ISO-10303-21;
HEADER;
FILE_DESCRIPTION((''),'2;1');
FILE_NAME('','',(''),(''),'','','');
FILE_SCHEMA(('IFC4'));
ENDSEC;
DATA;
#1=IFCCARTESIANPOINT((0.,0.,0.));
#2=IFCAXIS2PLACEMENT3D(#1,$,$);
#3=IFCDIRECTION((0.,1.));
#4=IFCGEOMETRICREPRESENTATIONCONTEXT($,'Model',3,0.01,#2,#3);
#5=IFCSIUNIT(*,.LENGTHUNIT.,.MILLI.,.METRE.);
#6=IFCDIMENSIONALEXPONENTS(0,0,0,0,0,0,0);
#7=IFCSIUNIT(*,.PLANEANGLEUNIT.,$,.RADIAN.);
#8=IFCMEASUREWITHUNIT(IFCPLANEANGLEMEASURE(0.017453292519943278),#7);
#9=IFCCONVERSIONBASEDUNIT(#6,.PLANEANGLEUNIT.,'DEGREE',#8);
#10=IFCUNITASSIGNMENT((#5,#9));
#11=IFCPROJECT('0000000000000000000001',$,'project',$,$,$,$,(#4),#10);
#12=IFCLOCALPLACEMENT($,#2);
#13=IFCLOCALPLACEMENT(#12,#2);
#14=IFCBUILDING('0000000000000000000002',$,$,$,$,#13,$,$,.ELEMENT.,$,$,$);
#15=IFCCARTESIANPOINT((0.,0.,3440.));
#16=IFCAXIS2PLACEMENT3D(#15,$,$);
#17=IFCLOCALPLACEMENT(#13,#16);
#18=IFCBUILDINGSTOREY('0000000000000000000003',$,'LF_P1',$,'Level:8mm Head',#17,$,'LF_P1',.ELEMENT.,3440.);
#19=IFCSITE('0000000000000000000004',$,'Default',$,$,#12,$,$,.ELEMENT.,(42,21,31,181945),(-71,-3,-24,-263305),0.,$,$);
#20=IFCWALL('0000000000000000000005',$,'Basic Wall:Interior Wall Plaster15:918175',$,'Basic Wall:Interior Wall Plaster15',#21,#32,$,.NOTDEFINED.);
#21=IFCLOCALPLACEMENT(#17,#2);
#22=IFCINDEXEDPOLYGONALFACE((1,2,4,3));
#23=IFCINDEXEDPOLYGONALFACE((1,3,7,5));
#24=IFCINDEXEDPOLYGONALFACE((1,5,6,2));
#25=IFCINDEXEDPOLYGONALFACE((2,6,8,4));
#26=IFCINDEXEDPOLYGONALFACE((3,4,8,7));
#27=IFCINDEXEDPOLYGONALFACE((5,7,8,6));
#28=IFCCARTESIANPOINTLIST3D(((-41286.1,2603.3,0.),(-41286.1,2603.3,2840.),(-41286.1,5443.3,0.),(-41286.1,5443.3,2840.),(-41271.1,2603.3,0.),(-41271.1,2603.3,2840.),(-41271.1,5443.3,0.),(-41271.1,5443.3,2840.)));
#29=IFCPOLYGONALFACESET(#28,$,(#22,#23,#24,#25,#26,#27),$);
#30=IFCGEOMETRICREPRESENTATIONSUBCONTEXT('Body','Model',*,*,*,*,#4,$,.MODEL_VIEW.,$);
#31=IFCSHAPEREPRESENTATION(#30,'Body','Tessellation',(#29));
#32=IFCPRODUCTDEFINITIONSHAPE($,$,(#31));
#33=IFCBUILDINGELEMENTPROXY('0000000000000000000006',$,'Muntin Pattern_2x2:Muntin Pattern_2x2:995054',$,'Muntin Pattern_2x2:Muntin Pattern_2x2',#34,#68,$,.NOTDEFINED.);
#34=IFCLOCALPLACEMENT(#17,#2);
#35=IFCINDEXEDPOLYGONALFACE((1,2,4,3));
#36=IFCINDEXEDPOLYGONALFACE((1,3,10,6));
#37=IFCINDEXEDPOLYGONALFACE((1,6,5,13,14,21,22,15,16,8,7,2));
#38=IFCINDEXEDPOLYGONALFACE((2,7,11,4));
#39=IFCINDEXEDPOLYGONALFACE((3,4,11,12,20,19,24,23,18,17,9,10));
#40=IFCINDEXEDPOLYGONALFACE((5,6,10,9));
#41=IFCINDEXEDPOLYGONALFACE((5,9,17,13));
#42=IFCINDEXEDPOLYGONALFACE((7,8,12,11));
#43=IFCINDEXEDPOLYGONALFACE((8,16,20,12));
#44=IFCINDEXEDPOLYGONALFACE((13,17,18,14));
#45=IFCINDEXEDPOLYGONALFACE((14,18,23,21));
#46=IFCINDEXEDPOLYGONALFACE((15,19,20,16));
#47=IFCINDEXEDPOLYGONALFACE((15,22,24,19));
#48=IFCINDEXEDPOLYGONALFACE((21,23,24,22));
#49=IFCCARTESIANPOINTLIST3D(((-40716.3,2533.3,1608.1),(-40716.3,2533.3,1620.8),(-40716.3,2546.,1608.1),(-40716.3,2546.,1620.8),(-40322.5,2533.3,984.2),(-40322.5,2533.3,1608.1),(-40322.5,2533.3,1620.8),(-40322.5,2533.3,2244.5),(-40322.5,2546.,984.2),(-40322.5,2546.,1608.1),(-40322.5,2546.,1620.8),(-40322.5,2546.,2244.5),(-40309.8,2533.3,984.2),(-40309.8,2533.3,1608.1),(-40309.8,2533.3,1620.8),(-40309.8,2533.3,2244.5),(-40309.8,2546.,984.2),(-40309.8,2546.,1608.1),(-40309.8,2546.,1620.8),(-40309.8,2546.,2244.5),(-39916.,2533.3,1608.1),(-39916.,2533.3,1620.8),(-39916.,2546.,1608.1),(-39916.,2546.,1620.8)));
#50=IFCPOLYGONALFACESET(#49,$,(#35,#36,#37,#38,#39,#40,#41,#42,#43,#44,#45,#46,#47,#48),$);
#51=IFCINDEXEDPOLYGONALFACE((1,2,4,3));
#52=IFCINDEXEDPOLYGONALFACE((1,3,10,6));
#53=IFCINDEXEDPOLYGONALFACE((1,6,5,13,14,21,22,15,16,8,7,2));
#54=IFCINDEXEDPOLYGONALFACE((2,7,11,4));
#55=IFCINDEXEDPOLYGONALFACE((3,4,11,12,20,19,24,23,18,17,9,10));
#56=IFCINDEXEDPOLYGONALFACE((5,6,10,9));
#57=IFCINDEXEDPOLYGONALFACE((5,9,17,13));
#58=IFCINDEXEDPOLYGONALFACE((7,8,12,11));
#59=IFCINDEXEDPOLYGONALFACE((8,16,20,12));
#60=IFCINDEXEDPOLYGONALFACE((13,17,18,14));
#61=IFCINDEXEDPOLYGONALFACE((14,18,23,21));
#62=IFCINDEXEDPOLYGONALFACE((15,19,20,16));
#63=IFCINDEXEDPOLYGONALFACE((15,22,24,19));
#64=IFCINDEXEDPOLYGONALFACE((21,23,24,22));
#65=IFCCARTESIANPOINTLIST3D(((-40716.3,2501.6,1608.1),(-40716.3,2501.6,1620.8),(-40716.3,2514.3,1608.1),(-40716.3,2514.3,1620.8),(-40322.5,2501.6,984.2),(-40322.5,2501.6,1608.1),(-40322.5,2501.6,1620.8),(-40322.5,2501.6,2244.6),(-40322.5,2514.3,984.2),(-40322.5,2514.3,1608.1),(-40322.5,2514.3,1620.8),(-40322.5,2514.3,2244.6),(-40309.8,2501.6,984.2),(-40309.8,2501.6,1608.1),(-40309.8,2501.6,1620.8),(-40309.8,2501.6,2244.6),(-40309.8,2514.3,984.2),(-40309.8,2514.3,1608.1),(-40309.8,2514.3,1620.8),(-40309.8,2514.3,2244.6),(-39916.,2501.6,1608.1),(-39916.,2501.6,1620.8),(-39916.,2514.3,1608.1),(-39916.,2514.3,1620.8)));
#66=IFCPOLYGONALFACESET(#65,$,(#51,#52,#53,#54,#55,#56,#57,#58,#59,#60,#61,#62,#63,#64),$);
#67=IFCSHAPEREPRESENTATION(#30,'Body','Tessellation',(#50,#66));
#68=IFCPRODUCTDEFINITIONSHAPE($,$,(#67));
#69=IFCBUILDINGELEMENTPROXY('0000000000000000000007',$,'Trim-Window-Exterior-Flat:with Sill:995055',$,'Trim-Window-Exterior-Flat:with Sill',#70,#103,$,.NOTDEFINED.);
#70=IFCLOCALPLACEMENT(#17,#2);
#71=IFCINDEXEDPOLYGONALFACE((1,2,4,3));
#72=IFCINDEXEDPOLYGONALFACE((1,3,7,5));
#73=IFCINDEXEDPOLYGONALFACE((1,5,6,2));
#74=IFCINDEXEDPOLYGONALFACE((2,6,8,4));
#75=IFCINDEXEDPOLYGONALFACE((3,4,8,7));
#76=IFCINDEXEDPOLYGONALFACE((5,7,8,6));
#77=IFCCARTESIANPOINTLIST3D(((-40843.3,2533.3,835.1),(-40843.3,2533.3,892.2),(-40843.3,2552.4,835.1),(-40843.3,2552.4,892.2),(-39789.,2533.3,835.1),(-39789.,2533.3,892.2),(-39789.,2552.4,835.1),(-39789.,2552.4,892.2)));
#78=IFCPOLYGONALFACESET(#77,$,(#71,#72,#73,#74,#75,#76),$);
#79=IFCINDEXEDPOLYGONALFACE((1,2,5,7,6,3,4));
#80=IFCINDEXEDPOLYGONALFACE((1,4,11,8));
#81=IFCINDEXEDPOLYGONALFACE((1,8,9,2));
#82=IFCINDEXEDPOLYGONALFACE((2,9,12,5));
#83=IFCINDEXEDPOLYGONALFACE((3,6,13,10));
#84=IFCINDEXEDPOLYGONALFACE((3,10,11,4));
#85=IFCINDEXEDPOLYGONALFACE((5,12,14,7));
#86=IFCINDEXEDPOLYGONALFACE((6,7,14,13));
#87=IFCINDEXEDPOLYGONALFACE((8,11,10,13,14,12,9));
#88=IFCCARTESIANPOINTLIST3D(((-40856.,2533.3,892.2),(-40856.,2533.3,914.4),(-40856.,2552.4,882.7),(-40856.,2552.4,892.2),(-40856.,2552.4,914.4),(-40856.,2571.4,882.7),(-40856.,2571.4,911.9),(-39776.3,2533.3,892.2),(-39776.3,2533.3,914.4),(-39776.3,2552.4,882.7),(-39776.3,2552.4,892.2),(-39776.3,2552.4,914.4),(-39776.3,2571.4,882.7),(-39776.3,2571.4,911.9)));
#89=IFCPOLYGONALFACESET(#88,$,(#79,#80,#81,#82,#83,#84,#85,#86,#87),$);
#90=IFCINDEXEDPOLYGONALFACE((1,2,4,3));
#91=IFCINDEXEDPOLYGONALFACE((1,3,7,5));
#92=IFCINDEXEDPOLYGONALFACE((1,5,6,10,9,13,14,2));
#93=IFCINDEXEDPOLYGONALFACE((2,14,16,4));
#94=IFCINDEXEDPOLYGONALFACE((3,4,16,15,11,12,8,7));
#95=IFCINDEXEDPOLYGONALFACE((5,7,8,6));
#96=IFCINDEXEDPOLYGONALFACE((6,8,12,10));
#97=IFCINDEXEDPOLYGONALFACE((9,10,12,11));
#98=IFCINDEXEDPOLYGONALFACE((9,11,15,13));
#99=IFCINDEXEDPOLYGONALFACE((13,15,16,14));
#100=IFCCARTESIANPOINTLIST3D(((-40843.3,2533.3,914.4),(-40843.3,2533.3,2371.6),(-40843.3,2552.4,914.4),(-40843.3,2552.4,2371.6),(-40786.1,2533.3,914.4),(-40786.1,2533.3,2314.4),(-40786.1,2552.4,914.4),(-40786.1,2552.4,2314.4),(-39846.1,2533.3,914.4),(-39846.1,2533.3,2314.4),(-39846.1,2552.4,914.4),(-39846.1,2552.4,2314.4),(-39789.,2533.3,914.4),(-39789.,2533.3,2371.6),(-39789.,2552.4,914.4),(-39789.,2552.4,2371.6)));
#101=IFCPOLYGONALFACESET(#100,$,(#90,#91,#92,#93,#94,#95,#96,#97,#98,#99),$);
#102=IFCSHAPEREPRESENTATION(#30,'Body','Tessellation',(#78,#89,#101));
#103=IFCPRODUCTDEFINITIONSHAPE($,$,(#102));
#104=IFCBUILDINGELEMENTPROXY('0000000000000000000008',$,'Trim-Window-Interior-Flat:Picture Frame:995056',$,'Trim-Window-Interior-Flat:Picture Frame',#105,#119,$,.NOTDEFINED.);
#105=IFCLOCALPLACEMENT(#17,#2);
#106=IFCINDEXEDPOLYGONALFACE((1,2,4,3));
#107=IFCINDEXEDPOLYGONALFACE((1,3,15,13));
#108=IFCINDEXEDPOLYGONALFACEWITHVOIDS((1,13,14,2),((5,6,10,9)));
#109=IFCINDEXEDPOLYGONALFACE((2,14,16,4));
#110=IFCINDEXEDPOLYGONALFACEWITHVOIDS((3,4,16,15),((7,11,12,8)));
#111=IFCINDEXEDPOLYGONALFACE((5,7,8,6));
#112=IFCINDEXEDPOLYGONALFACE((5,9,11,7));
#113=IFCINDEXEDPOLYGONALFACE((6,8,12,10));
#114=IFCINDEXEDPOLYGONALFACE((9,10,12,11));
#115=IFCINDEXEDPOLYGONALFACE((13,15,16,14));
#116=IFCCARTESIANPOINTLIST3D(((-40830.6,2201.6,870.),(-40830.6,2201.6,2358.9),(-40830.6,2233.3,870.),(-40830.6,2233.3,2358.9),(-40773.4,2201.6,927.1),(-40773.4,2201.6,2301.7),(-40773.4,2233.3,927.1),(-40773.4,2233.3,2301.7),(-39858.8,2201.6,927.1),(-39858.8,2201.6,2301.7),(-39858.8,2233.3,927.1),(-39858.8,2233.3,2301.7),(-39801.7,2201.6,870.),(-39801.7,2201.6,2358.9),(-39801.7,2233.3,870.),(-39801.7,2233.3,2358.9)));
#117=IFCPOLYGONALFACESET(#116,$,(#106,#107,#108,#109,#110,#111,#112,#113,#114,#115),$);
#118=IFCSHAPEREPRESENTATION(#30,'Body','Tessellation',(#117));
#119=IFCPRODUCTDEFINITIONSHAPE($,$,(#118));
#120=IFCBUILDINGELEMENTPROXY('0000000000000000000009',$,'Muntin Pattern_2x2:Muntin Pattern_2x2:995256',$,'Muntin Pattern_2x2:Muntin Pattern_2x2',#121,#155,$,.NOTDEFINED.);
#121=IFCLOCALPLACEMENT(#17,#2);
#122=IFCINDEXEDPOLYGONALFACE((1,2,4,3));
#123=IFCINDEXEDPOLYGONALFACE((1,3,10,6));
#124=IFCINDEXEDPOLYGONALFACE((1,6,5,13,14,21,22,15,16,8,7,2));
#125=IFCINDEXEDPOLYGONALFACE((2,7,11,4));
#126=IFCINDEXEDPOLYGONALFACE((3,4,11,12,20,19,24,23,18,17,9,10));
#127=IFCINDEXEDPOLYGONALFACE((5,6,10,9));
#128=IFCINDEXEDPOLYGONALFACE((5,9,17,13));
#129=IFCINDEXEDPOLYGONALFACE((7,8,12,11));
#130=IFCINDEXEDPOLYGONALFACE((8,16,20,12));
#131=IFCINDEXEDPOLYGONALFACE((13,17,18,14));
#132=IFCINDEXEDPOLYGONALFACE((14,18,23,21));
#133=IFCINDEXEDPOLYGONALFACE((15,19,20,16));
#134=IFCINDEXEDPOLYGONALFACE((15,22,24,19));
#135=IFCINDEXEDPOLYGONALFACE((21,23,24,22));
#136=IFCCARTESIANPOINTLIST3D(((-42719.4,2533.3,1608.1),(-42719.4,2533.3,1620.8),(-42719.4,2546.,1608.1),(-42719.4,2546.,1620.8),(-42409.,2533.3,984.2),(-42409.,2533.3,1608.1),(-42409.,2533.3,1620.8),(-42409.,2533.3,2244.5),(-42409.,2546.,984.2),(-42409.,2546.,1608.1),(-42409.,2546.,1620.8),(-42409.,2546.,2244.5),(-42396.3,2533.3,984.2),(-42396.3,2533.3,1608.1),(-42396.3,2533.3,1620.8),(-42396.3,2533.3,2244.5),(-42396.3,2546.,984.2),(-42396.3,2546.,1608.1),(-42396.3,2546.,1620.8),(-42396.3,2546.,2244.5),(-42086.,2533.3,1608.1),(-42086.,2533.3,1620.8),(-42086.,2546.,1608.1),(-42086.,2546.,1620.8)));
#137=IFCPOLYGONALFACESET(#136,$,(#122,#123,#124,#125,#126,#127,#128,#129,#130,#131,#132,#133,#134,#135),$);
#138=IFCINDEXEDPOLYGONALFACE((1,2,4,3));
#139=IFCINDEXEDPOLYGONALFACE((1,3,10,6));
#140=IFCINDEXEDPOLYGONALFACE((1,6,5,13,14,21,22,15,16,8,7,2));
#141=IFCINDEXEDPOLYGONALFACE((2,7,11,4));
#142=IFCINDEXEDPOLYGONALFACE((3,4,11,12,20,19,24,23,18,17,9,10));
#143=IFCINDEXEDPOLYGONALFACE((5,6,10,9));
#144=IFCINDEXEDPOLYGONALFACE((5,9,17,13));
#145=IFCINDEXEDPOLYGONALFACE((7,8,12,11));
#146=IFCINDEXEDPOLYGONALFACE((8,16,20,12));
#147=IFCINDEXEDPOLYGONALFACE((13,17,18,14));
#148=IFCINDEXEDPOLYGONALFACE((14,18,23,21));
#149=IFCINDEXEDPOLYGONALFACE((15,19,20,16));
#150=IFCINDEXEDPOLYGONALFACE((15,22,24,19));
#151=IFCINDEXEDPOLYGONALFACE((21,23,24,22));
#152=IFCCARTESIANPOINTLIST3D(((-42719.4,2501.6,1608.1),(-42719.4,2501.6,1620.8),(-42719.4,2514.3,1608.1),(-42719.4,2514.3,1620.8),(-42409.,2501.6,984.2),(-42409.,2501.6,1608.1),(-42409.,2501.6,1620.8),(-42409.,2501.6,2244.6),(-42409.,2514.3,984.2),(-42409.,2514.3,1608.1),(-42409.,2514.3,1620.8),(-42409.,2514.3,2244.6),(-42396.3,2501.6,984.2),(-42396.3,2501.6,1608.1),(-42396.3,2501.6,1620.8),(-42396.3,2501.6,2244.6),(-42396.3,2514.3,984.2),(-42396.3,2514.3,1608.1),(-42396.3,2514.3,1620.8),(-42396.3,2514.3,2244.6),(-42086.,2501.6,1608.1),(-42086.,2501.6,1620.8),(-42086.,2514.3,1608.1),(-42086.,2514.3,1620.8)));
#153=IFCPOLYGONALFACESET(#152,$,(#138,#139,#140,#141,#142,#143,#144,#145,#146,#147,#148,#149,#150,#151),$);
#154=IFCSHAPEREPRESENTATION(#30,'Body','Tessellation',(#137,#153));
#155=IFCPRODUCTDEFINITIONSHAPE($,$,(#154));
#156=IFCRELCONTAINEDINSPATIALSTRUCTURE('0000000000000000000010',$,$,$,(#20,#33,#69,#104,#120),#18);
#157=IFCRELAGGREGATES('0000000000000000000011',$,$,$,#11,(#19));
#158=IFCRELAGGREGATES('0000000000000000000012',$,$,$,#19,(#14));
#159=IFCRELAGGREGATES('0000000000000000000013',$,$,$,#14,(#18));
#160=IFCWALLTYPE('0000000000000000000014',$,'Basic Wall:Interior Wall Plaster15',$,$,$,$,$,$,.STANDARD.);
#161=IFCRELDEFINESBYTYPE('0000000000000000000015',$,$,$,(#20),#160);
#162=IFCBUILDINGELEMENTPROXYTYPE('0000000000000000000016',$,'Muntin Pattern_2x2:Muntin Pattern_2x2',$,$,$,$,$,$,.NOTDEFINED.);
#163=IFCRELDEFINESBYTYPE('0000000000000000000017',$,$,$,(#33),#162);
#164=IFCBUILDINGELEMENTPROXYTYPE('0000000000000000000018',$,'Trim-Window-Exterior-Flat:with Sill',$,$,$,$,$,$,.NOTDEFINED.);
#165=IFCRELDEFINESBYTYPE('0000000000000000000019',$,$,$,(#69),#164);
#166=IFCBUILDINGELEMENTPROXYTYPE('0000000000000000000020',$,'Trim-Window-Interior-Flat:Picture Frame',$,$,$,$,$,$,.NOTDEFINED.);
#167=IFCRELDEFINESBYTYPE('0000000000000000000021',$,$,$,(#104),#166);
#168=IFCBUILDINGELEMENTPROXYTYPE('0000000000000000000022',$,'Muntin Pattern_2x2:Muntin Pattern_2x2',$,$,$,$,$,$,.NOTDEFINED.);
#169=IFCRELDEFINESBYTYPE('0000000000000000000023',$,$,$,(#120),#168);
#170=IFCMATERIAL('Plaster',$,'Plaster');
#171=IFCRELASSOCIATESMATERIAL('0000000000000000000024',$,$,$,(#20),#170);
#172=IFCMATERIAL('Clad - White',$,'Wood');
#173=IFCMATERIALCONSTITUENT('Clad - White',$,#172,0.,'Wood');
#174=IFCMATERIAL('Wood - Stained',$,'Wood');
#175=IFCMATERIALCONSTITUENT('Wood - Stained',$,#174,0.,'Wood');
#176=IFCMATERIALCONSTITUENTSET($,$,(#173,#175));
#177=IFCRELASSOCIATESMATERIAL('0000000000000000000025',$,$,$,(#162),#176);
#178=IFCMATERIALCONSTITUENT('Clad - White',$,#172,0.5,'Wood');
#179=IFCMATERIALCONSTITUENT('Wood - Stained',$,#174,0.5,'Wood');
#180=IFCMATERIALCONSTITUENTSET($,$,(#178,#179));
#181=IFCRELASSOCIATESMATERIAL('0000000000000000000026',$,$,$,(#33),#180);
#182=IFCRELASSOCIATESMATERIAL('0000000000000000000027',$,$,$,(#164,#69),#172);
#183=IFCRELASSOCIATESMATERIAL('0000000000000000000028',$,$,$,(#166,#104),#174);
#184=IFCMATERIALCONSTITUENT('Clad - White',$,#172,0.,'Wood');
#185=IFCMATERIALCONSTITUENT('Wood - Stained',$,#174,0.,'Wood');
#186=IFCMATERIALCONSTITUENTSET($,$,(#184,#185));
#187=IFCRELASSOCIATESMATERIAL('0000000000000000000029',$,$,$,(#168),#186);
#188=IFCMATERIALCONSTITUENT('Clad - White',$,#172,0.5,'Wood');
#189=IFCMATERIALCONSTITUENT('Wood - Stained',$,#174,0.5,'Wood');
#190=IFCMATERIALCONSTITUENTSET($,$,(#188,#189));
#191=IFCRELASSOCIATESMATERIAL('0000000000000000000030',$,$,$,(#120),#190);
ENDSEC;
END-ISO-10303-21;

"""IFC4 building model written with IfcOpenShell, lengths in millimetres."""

from ifc_helpers import new_model, entity, si_unit, converted_unit, direction, frame, origin, place, context, subcontext, project, spatial, indexed_curve, outline, extrude, source, transform, mapped, material, constituent, constituent_set, type_object, type_shapes, element, save


model = new_model("IFC4")

# Units and contexts
model_context = context("Model", 3, precision=0.01, world=origin(), true_north=direction((0.0, 1.0)))
body_context = subcontext(model_context, "Body", "Model", "MODEL_VIEW")
ifc_project = project(units=[si_unit("LENGTHUNIT", "METRE", prefix="MILLI"), converted_unit("PLANEANGLEUNIT", "DEGREE", entity("IfcPlaneAngleMeasure", 0.017453292519943278), si_unit("PLANEANGLEUNIT", "RADIAN"), dimensions=[0, 0, 0, 0, 0, 0, 0])], contexts=[model_context])

# Site, building, storey
site_placement = place(None, origin())
site = spatial("IfcSite", under=ifc_project, at=site_placement, Name="Default", CompositionType="ELEMENT", RefLatitude=(42, 21, 31, 181945), RefLongitude=(-71, -3, -24, -263305), RefElevation=0.0)
building_placement = place(site_placement, origin())
building = spatial("IfcBuilding", under=site, at=building_placement, CompositionType="ELEMENT")
storey_placement = place(building_placement, frame((0.0, 0.0, 3440.0)))
storey = spatial("IfcBuildingStorey", under=building, at=storey_placement, Name="LF_P1", ObjectType="Level:8mm Head", LongName="LF_P1", CompositionType="ELEMENT", Elevation=3440.0)

# Wall
ifc_material_1 = material(Name="Plaster", Category="Plaster")
wall_type_1 = type_object("IfcWallType", Name="Basic Wall:Interior Wall Plaster15", PredefinedType="STANDARD")
wall_1_placement = place(storey_placement, frame((-41278.6, 5443.3, 0.0), z_axis=(0.0, 0.0, 1.0), x_axis=(0.0, -1.0, 0.0)))
element("IfcWall", 1, at=wall_1_placement, inside=storey, type_object=wall_type_1, material=ifc_material_1, Name="Basic Wall:Interior Wall Plaster15:918175", ObjectType="Basic Wall:Interior Wall Plaster15", PredefinedType="NOTDEFINED", context=body_context, shape_type="SweptSolid", body=[
    extrude(outline(indexed_curve([(2840.0, 7.5), (0.0, 7.5), (0.0, -7.5), (2840.0, -7.5), (2840.0, 7.5)], self_intersect=False)), origin(), (0.0, 0.0, 1.0), 2840.0),
])

# Building element proxies
ifc_material_2 = material(Name="Clad - White", Category="Wood")
ifc_constituent_1 = constituent(ifc_material_2, Name="Clad - White", Category="Wood", fraction=0.5)
ifc_material_3 = material(Name="Wood - Stained", Category="Wood")
ifc_constituent_2 = constituent(ifc_material_3, Name="Wood - Stained", Category="Wood", fraction=0.5)
ifc_constituent_set_1 = constituent_set(constituents=[ifc_constituent_1, ifc_constituent_2])
ifc_constituent_3 = constituent(ifc_material_2, Name="Clad - White", Category="Wood", fraction=0.0)
ifc_constituent_4 = constituent(ifc_material_3, Name="Wood - Stained", Category="Wood", fraction=0.0)
ifc_constituent_set_2 = constituent_set(constituents=[ifc_constituent_3, ifc_constituent_4])
building_element_proxy_type_1 = type_object("IfcBuildingElementProxyType", Name="Muntin Pattern_2x2:Muntin Pattern_2x2", PredefinedType="NOTDEFINED", material=ifc_constituent_set_2)
shared_shape_1 = source(origin(), body_context, "Body", "SweptSolid", [
    extrude(outline(indexed_curve([(6.4, -6.4), (630.1, -6.4), (630.1, 6.3), (6.4, 6.3), (6.4, 400.2), (-6.3, 400.2), (-6.3, 6.3), (-630.2, 6.3), (-630.2, -6.4), (-6.3, -6.4), (-6.3, -400.1), (6.4, -400.1), (6.4, -6.4)], self_intersect=False)), frame((0.0, -22.2, 630.1), z_axis=(0.0, 1.0, 0.0), x_axis=(0.0, 0.0, 1.0)), (0.0, 0.0, 1.0), 12.7),
    extrude(outline(indexed_curve([(6.4, -6.4), (630.2, -6.4), (630.2, 6.3), (6.4, 6.3), (6.4, 400.2), (-6.3, 400.2), (-6.3, 6.3), (-630.2, 6.3), (-630.2, -6.4), (-6.3, -6.4), (-6.3, -400.1), (6.4, -400.1), (6.4, -6.4)], self_intersect=False)), frame((0.0, 9.5, 630.2), z_axis=(0.0, 1.0, 0.0), x_axis=(0.0, 0.0, 1.0)), (0.0, 0.0, 1.0), 12.7),
])
type_shapes(building_element_proxy_type_1, [shared_shape_1])
proxy_1_placement = place(storey_placement, frame((-40316.1, 2523.8, 984.2), z_axis=(0.0, 0.0, 1.0), x_axis=(-1.0, 0.0, 0.0)))
element("IfcBuildingElementProxy", 2, at=proxy_1_placement, inside=storey, type_object=building_element_proxy_type_1, material=ifc_constituent_set_1, Name="Muntin Pattern_2x2:Muntin Pattern_2x2:995054", ObjectType="Muntin Pattern_2x2:Muntin Pattern_2x2", PredefinedType="NOTDEFINED", context=body_context, shape_type="MappedRepresentation", body=[
    mapped(shared_shape_1, transform((0.0, 0.0, 0.0), scale=1.0)),
])
building_element_proxy_type_2 = type_object("IfcBuildingElementProxyType", Name="Trim-Window-Exterior-Flat:with Sill", PredefinedType="NOTDEFINED", material=ifc_material_2)
shared_shape_2 = source(origin(), body_context, "Body", "SweptSolid", [
    extrude(outline(indexed_curve([(-28.6, -527.1), (28.6, -527.1), (28.6, 527.1), (-28.6, 527.1), (-28.6, -527.1)], self_intersect=False)), frame((0.0, 1450.8, 0.0), z_axis=(0.0, 0.0, 1.0), x_axis=(0.0, 1.0, 0.0)), (0.0, 0.0, 1.0), 19.0),
    extrude(outline(indexed_curve([(-16.0, -19.0), (13.3, -19.0), (15.8, 0.0), (15.8, 19.0), (-6.4, 19.0), (-6.4, 0.0), (-16.0, 0.0), (-16.0, -19.0)], self_intersect=False)), frame((-539.8, 1415.8, 19.0), z_axis=(1.0, 0.0, 0.0), x_axis=(0.0, -1.0, 0.0)), (0.0, 0.0, 1.0), 1079.7),
    extrude(outline(indexed_curve([(-527.1, -742.9), (527.1, -742.9), (527.1, 714.3), (470.0, 714.3), (470.0, -685.7), (-470.0, -685.7), (-470.0, 714.3), (-527.1, 714.3), (-527.1, -742.9)], self_intersect=False)), frame((0.0, 685.7, 0.0)), (0.0, 0.0, 1.0), 19.0),
])
type_shapes(building_element_proxy_type_2, [shared_shape_2])
proxy_2_placement = place(storey_placement, frame((-40316.1, 2533.3, 2314.4), z_axis=(0.0, 1.0, 0.0), x_axis=(1.0, 0.0, 0.0)))
element("IfcBuildingElementProxy", 3, at=proxy_2_placement, inside=storey, type_object=building_element_proxy_type_2, material=ifc_material_2, Name="Trim-Window-Exterior-Flat:with Sill:995055", ObjectType="Trim-Window-Exterior-Flat:with Sill", PredefinedType="NOTDEFINED", context=body_context, shape_type="MappedRepresentation", body=[
    mapped(shared_shape_2, transform((0.0, 0.0, 0.0), scale=1.0)),
])
building_element_proxy_type_3 = type_object("IfcBuildingElementProxyType", Name="Trim-Window-Interior-Flat:Picture Frame", PredefinedType="NOTDEFINED", material=ifc_material_3)
shared_shape_3 = source(origin(), body_context, "Body", "SweptSolid", [
    extrude(outline(indexed_curve([(-744.4, -514.4), (744.4, -514.4), (744.4, 514.4), (-744.4, 514.4), (-744.4, -514.4)], self_intersect=False), holes=[indexed_curve([(-687.3, -457.3), (-687.3, 457.3), (687.3, 457.3), (687.3, -457.3), (-687.3, -457.3)], self_intersect=False)]), frame((0.0, 700.0, 0.0), z_axis=(0.0, 0.0, 1.0), x_axis=(0.0, 1.0, 0.0)), (0.0, 0.0, 1.0), 31.7),
])
type_shapes(building_element_proxy_type_3, [shared_shape_3])
proxy_3_placement = place(storey_placement, frame((-40316.1, 2233.3, 2314.4), z_axis=(0.0, -1.0, 0.0), x_axis=(-1.0, 0.0, 0.0)))
element("IfcBuildingElementProxy", 4, at=proxy_3_placement, inside=storey, type_object=building_element_proxy_type_3, material=ifc_material_3, Name="Trim-Window-Interior-Flat:Picture Frame:995056", ObjectType="Trim-Window-Interior-Flat:Picture Frame", PredefinedType="NOTDEFINED", context=body_context, shape_type="MappedRepresentation", body=[
    mapped(shared_shape_3, transform((0.0, 0.0, 0.0), scale=1.0)),
])
ifc_constituent_5 = constituent(ifc_material_2, Name="Clad - White", Category="Wood", fraction=0.5)
ifc_constituent_6 = constituent(ifc_material_3, Name="Wood - Stained", Category="Wood", fraction=0.5)
ifc_constituent_set_3 = constituent_set(constituents=[ifc_constituent_5, ifc_constituent_6])
ifc_constituent_7 = constituent(ifc_material_2, Name="Clad - White", Category="Wood", fraction=0.0)
ifc_constituent_8 = constituent(ifc_material_3, Name="Wood - Stained", Category="Wood", fraction=0.0)
ifc_constituent_set_4 = constituent_set(constituents=[ifc_constituent_7, ifc_constituent_8])
building_element_proxy_type_4 = type_object("IfcBuildingElementProxyType", Name="Muntin Pattern_2x2:Muntin Pattern_2x2", PredefinedType="NOTDEFINED", material=ifc_constituent_set_4)
shared_shape_4 = source(origin(), body_context, "Body", "SweptSolid", [
    extrude(outline(indexed_curve([(6.4, -6.4), (630.1, -6.4), (630.1, 6.3), (6.4, 6.3), (6.4, 316.7), (-6.3, 316.7), (-6.3, 6.3), (-630.2, 6.3), (-630.2, -6.4), (-6.3, -6.4), (-6.3, -316.7), (6.4, -316.7), (6.4, -6.4)], self_intersect=False)), frame((0.0, -22.2, 630.1), z_axis=(0.0, 1.0, 0.0), x_axis=(0.0, 0.0, 1.0)), (0.0, 0.0, 1.0), 12.7),
    extrude(outline(indexed_curve([(6.4, -6.4), (630.2, -6.4), (630.2, 6.3), (6.4, 6.3), (6.4, 316.7), (-6.3, 316.7), (-6.3, 6.3), (-630.2, 6.3), (-630.2, -6.4), (-6.3, -6.4), (-6.3, -316.7), (6.4, -316.7), (6.4, -6.4)], self_intersect=False)), frame((0.0, 9.5, 630.2), z_axis=(0.0, 1.0, 0.0), x_axis=(0.0, 0.0, 1.0)), (0.0, 0.0, 1.0), 12.7),
])
type_shapes(building_element_proxy_type_4, [shared_shape_4])
proxy_4_placement = place(storey_placement, frame((-42402.7, 2523.8, 984.3), z_axis=(0.0, 0.0, 1.0), x_axis=(-1.0, 0.0, 0.0)))
element("IfcBuildingElementProxy", 5, at=proxy_4_placement, inside=storey, type_object=building_element_proxy_type_4, material=ifc_constituent_set_3, Name="Muntin Pattern_2x2:Muntin Pattern_2x2:995256", ObjectType="Muntin Pattern_2x2:Muntin Pattern_2x2", PredefinedType="NOTDEFINED", context=body_context, shape_type="MappedRepresentation", body=[
    mapped(shared_shape_4, transform((0.0, 0.0, 0.0), scale=1.0)),
])

save(model, "model.ifc")
